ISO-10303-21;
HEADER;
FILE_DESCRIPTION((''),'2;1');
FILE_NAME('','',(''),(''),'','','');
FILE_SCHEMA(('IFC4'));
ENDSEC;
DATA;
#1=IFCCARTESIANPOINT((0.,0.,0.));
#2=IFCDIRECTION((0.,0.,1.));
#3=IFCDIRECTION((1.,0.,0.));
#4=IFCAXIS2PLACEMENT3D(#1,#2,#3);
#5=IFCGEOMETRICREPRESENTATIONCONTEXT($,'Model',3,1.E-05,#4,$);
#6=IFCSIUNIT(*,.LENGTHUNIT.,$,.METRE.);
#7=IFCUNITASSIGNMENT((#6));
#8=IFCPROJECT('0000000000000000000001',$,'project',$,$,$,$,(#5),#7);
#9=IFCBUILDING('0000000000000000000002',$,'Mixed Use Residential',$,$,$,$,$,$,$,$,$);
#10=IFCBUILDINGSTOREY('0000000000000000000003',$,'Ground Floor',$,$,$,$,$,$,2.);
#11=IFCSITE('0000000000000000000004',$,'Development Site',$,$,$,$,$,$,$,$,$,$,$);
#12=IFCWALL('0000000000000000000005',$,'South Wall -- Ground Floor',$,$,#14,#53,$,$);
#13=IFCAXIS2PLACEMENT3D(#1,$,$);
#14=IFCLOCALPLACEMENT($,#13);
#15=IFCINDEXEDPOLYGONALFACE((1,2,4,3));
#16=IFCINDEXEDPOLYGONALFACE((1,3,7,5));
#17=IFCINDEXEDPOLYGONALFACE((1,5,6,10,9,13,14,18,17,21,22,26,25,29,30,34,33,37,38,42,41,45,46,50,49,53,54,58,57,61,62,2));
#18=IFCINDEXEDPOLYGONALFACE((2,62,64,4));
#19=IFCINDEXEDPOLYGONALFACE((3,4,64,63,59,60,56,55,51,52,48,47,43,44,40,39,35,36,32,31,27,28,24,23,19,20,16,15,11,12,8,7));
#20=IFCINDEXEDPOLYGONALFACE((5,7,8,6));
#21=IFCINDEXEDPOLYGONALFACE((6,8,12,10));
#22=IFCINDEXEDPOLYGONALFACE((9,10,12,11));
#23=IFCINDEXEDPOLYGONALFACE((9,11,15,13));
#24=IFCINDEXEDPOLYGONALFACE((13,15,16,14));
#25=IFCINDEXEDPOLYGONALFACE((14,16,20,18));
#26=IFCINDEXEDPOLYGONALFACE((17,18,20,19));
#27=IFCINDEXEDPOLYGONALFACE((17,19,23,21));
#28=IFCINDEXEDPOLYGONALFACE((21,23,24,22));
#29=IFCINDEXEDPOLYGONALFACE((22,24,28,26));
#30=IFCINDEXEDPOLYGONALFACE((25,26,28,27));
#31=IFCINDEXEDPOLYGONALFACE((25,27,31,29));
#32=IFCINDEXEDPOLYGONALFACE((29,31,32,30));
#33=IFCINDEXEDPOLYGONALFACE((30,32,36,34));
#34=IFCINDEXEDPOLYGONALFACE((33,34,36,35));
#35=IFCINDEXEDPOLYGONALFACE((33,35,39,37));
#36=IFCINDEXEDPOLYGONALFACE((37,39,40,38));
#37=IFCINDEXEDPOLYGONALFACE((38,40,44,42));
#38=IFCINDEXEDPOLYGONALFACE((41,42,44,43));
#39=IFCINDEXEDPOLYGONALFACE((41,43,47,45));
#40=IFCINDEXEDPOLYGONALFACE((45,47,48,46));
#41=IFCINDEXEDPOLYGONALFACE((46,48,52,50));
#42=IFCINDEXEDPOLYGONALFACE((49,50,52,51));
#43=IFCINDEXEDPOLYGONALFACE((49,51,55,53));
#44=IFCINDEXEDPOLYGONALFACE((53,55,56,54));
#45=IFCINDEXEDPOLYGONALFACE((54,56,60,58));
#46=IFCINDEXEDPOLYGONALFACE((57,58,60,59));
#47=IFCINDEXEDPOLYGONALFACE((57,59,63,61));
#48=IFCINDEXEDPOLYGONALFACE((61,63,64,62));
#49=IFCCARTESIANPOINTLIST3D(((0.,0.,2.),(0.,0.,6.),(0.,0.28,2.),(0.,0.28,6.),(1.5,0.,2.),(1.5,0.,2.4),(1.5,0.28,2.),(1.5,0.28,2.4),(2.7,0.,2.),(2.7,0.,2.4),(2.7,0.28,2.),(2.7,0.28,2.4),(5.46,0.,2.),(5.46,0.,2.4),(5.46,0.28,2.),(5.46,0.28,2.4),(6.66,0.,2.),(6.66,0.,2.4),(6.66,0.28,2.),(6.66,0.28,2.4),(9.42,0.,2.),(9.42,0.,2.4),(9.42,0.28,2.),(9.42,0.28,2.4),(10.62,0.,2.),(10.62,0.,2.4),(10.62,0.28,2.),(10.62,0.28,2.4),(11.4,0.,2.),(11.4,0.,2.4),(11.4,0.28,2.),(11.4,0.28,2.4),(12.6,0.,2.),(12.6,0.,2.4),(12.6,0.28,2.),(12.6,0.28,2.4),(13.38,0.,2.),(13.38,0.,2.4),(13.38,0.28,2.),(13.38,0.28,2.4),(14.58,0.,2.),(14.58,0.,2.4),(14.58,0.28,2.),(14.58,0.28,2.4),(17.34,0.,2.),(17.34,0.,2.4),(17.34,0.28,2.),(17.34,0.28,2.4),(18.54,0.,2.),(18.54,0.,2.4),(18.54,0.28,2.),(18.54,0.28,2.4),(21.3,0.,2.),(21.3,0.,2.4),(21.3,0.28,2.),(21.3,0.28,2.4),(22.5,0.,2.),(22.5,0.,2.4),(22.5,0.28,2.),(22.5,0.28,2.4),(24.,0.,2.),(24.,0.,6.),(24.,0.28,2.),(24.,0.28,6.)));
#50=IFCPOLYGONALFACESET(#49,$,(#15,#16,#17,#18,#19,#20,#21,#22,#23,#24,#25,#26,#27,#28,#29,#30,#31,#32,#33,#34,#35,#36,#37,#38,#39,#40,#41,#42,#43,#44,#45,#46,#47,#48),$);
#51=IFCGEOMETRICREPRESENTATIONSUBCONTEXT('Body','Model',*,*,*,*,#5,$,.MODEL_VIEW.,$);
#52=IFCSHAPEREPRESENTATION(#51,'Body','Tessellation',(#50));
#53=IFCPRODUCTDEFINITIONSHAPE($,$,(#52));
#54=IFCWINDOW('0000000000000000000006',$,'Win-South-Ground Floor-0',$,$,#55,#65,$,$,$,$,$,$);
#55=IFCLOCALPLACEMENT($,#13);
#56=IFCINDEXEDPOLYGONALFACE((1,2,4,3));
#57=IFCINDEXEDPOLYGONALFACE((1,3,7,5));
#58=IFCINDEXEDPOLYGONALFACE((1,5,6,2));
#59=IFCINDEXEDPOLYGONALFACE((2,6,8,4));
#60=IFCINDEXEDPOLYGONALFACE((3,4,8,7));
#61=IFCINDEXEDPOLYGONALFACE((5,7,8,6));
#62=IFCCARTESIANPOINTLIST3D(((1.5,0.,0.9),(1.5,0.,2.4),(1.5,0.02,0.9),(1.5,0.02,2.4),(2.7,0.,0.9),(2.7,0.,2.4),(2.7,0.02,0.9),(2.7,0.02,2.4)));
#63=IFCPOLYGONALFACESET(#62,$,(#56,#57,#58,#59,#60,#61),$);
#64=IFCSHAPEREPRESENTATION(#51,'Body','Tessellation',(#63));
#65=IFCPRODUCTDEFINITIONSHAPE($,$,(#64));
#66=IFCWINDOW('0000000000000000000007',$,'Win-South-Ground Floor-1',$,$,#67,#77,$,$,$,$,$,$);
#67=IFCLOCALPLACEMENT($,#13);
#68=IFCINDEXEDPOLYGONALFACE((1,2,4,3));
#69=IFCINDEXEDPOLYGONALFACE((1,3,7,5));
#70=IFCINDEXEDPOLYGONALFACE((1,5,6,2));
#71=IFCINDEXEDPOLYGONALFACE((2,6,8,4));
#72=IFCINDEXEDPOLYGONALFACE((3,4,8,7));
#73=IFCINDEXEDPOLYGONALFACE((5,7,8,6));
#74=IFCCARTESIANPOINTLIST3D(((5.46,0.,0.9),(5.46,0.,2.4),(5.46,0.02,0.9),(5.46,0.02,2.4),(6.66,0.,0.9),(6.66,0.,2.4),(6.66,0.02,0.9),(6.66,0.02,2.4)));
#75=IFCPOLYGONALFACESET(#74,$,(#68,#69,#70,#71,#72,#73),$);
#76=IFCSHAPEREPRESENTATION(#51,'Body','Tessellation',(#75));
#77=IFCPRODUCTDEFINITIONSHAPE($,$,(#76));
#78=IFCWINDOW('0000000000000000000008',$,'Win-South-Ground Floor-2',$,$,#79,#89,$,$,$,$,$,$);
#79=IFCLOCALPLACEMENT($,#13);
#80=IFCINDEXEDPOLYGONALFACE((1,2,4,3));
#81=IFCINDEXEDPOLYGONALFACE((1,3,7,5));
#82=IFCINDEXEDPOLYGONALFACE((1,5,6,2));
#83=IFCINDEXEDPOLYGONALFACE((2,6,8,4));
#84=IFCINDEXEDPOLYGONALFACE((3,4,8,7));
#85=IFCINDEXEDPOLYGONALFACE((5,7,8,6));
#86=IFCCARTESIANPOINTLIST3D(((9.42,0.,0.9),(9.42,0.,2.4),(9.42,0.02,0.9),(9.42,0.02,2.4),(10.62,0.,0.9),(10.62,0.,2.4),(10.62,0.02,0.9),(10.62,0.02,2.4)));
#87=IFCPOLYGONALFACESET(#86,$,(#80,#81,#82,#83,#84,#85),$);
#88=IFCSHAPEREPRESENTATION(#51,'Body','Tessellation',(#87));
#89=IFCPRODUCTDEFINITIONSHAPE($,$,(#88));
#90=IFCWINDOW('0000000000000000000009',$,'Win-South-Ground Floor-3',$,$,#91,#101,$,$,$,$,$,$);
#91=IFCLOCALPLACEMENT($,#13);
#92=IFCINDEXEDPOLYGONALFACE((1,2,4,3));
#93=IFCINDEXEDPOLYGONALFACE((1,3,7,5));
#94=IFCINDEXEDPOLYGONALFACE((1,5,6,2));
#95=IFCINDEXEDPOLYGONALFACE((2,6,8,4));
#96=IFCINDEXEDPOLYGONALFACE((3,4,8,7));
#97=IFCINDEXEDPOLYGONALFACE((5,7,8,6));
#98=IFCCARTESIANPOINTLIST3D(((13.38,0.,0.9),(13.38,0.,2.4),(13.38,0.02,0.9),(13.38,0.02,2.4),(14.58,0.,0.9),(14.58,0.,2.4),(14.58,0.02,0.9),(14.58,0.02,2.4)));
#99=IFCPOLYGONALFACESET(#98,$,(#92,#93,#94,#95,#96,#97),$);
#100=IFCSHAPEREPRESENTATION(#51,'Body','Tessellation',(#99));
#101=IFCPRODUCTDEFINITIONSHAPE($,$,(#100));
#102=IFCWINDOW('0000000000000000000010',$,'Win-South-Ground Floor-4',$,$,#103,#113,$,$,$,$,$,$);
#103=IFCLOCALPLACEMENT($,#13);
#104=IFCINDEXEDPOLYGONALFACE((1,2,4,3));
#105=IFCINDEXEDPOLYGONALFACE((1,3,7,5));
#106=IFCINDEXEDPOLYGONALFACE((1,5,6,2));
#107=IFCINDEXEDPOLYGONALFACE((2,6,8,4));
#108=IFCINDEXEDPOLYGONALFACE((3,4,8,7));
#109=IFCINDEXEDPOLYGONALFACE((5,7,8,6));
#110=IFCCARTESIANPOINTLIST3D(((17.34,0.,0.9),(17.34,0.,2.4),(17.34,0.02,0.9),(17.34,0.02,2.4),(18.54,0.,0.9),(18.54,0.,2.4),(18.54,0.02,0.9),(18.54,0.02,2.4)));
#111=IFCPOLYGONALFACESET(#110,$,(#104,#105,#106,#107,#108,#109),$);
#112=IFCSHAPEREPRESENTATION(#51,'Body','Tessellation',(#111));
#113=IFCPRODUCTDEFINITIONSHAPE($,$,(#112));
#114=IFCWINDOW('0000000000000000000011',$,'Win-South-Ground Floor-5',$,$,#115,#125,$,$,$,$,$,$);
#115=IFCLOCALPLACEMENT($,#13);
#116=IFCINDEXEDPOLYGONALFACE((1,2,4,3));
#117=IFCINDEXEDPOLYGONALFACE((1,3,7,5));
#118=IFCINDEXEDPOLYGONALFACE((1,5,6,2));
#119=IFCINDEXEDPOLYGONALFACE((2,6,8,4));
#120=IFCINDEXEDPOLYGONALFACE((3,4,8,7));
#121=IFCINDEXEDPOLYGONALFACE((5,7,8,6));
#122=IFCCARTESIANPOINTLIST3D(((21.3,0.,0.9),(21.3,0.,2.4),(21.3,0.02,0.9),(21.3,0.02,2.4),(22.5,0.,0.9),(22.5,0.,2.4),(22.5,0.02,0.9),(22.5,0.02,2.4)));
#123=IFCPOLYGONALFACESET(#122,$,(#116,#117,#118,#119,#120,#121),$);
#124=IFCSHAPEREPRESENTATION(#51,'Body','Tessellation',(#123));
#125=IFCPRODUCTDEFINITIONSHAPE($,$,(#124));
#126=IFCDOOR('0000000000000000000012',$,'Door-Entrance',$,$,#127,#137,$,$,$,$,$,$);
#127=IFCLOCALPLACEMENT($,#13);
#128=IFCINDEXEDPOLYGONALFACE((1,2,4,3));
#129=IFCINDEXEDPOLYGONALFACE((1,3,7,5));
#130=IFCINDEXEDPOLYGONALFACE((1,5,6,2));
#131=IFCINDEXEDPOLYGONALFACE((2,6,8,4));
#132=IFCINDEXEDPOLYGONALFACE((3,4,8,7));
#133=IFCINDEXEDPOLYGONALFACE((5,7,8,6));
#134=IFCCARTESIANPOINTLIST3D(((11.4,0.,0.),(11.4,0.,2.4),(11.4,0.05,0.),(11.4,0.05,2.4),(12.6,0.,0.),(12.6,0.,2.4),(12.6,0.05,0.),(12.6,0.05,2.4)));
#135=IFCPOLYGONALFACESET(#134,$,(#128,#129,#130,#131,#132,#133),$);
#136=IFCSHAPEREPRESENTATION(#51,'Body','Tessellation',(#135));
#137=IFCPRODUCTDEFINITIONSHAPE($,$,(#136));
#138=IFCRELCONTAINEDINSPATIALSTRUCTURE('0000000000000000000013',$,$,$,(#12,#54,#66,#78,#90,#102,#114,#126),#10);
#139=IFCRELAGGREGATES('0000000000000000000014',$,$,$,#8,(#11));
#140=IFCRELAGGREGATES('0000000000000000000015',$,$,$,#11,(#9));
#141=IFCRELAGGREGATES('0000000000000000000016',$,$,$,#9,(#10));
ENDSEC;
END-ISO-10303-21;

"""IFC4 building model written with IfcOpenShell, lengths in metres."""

from ifc_helpers import new_model, si_unit, frame, origin_with_axes, place, context, subcontext, project, spatial, indexed_curve, outline, extrude, element, fill, save


model = new_model("IFC4")

# Units and contexts
model_context = context("Model", 3, precision=1e-05, world=origin_with_axes())
body_context = subcontext(model_context, "Body", "Model", "MODEL_VIEW")
ifc_project = project(units=[si_unit("LENGTHUNIT", "METRE")], contexts=[model_context])

# Site, building, storey
site = spatial("IfcSite", under=ifc_project, Name="Development Site")
building = spatial("IfcBuilding", under=site, Name="Mixed Use Residential")
storey = spatial("IfcBuildingStorey", under=building, Name="Ground Floor", Elevation=2.0)

# Wall, openings, windows, door
wall_1_placement = place(None, frame((0.0, 0.0, 2.0), z_axis=(0.0, 0.0, 1.0), x_axis=(1.0, 0.0, 0.0)))
wall_1 = element("IfcWall", 1, at=wall_1_placement, inside=storey, Name="South Wall -- Ground Floor", context=body_context, shape_type="SweptSolid", body=[
    extrude(outline(indexed_curve([(0.0, 0.0), (0.0, 0.28), (24.0, 0.28), (24.0, 0.0), (0.0, 0.0)], self_intersect=False)), origin_with_axes(), (0.0, 0.0, 1.0), 4.0),
])
opening_1_placement = place(wall_1_placement, frame((1.5, 0.0, -1.1), z_axis=(0.0, 0.0, 1.0), x_axis=(1.0, 0.0, 0.0)))
opening_1 = element("IfcOpeningElement", 2, at=opening_1_placement, cuts=wall_1, context=body_context, shape_type="SweptSolid", body=[
    extrude(outline(indexed_curve([(0.0, 0.0), (0.0, 0.28), (1.2, 0.28), (1.2, 0.0), (0.0, 0.0)], self_intersect=False)), origin_with_axes(), (0.0, 0.0, 1.0), 1.5),
])
opening_2_placement = place(wall_1_placement, frame((5.46, 0.0, -1.1), z_axis=(0.0, 0.0, 1.0), x_axis=(1.0, 0.0, 0.0)))
opening_2 = element("IfcOpeningElement", 3, at=opening_2_placement, cuts=wall_1, context=body_context, shape_type="SweptSolid", body=[
    extrude(outline(indexed_curve([(0.0, 0.0), (0.0, 0.28), (1.2, 0.28), (1.2, 0.0), (0.0, 0.0)], self_intersect=False)), origin_with_axes(), (0.0, 0.0, 1.0), 1.5),
])
opening_3_placement = place(wall_1_placement, frame((9.42, 0.0, -1.1), z_axis=(0.0, 0.0, 1.0), x_axis=(1.0, 0.0, 0.0)))
opening_3 = element("IfcOpeningElement", 4, at=opening_3_placement, cuts=wall_1, context=body_context, shape_type="SweptSolid", body=[
    extrude(outline(indexed_curve([(0.0, 0.0), (0.0, 0.28), (1.2, 0.28), (1.2, 0.0), (0.0, 0.0)], self_intersect=False)), origin_with_axes(), (0.0, 0.0, 1.0), 1.5),
])
opening_4_placement = place(wall_1_placement, frame((13.38, 0.0, -1.1), z_axis=(0.0, 0.0, 1.0), x_axis=(1.0, 0.0, 0.0)))
opening_4 = element("IfcOpeningElement", 5, at=opening_4_placement, cuts=wall_1, context=body_context, shape_type="SweptSolid", body=[
    extrude(outline(indexed_curve([(0.0, 0.0), (0.0, 0.28), (1.2, 0.28), (1.2, 0.0), (0.0, 0.0)], self_intersect=False)), origin_with_axes(), (0.0, 0.0, 1.0), 1.5),
])
opening_5_placement = place(wall_1_placement, frame((17.34, 0.0, -1.1), z_axis=(0.0, 0.0, 1.0), x_axis=(1.0, 0.0, 0.0)))
opening_5 = element("IfcOpeningElement", 6, at=opening_5_placement, cuts=wall_1, context=body_context, shape_type="SweptSolid", body=[
    extrude(outline(indexed_curve([(0.0, 0.0), (0.0, 0.28), (1.2, 0.28), (1.2, 0.0), (0.0, 0.0)], self_intersect=False)), origin_with_axes(), (0.0, 0.0, 1.0), 1.5),
])
opening_6_placement = place(wall_1_placement, frame((21.3, 0.0, -1.1), z_axis=(0.0, 0.0, 1.0), x_axis=(1.0, 0.0, 0.0)))
opening_6 = element("IfcOpeningElement", 7, at=opening_6_placement, cuts=wall_1, context=body_context, shape_type="SweptSolid", body=[
    extrude(outline(indexed_curve([(0.0, 0.0), (0.0, 0.28), (1.2, 0.28), (1.2, 0.0), (0.0, 0.0)], self_intersect=False)), origin_with_axes(), (0.0, 0.0, 1.0), 1.5),
])
opening_7_placement = place(wall_1_placement, frame((11.4, 0.0, -2.0), z_axis=(0.0, 0.0, 1.0), x_axis=(1.0, 0.0, 0.0)))
opening_7 = element("IfcOpeningElement", 8, at=opening_7_placement, cuts=wall_1, context=body_context, shape_type="SweptSolid", body=[
    extrude(outline(indexed_curve([(0.0, 0.0), (0.0, 0.28), (1.2, 0.28), (1.2, 0.0), (0.0, 0.0)], self_intersect=False)), origin_with_axes(), (0.0, 0.0, 1.0), 2.4),
])
window_1_placement = place(None, frame((1.5, 0.0, 0.9), z_axis=(0.0, 0.0, 1.0), x_axis=(1.0, 0.0, 0.0)))
window_1 = element("IfcWindow", 9, at=window_1_placement, inside=storey, Name="Win-South-Ground Floor-0", context=body_context, shape_type="SweptSolid", body=[
    extrude(outline(indexed_curve([(0.0, 0.0), (0.0, 0.02), (1.2, 0.02), (1.2, 0.0), (0.0, 0.0)], self_intersect=False)), origin_with_axes(), (0.0, 0.0, 1.0), 1.5),
])
fill(opening_1, window_1)
window_2_placement = place(None, frame((5.46, 0.0, 0.9), z_axis=(0.0, 0.0, 1.0), x_axis=(1.0, 0.0, 0.0)))
window_2 = element("IfcWindow", 10, at=window_2_placement, inside=storey, Name="Win-South-Ground Floor-1", context=body_context, shape_type="SweptSolid", body=[
    extrude(outline(indexed_curve([(0.0, 0.0), (0.0, 0.02), (1.2, 0.02), (1.2, 0.0), (0.0, 0.0)], self_intersect=False)), origin_with_axes(), (0.0, 0.0, 1.0), 1.5),
])
fill(opening_2, window_2)
window_3_placement = place(None, frame((9.42, 0.0, 0.9), z_axis=(0.0, 0.0, 1.0), x_axis=(1.0, 0.0, 0.0)))
window_3 = element("IfcWindow", 11, at=window_3_placement, inside=storey, Name="Win-South-Ground Floor-2", context=body_context, shape_type="SweptSolid", body=[
    extrude(outline(indexed_curve([(0.0, 0.0), (0.0, 0.02), (1.2, 0.02), (1.2, 0.0), (0.0, 0.0)], self_intersect=False)), origin_with_axes(), (0.0, 0.0, 1.0), 1.5),
])
fill(opening_3, window_3)
window_4_placement = place(None, frame((13.38, 0.0, 0.9), z_axis=(0.0, 0.0, 1.0), x_axis=(1.0, 0.0, 0.0)))
window_4 = element("IfcWindow", 12, at=window_4_placement, inside=storey, Name="Win-South-Ground Floor-3", context=body_context, shape_type="SweptSolid", body=[
    extrude(outline(indexed_curve([(0.0, 0.0), (0.0, 0.02), (1.2, 0.02), (1.2, 0.0), (0.0, 0.0)], self_intersect=False)), origin_with_axes(), (0.0, 0.0, 1.0), 1.5),
])
fill(opening_4, window_4)
window_5_placement = place(None, frame((17.34, 0.0, 0.9), z_axis=(0.0, 0.0, 1.0), x_axis=(1.0, 0.0, 0.0)))
window_5 = element("IfcWindow", 13, at=window_5_placement, inside=storey, Name="Win-South-Ground Floor-4", context=body_context, shape_type="SweptSolid", body=[
    extrude(outline(indexed_curve([(0.0, 0.0), (0.0, 0.02), (1.2, 0.02), (1.2, 0.0), (0.0, 0.0)], self_intersect=False)), origin_with_axes(), (0.0, 0.0, 1.0), 1.5),
])
fill(opening_5, window_5)
window_6_placement = place(None, frame((21.3, 0.0, 0.9), z_axis=(0.0, 0.0, 1.0), x_axis=(1.0, 0.0, 0.0)))
window_6 = element("IfcWindow", 14, at=window_6_placement, inside=storey, Name="Win-South-Ground Floor-5", context=body_context, shape_type="SweptSolid", body=[
    extrude(outline(indexed_curve([(0.0, 0.0), (0.0, 0.02), (1.2, 0.02), (1.2, 0.0), (0.0, 0.0)], self_intersect=False)), origin_with_axes(), (0.0, 0.0, 1.0), 1.5),
])
fill(opening_6, window_6)
door_placement = place(None, frame((11.4, 0.0, 0.0), z_axis=(0.0, 0.0, 1.0), x_axis=(1.0, 0.0, 0.0)))
door = element("IfcDoor", 15, at=door_placement, inside=storey, Name="Door-Entrance", context=body_context, shape_type="SweptSolid", body=[
    extrude(outline(indexed_curve([(0.0, 0.0), (0.0, 0.05), (1.2, 0.05), (1.2, 0.0), (0.0, 0.0)], self_intersect=False)), origin_with_axes(), (0.0, 0.0, 1.0), 2.4),
])
fill(opening_7, door)

save(model, "model.ifc")
